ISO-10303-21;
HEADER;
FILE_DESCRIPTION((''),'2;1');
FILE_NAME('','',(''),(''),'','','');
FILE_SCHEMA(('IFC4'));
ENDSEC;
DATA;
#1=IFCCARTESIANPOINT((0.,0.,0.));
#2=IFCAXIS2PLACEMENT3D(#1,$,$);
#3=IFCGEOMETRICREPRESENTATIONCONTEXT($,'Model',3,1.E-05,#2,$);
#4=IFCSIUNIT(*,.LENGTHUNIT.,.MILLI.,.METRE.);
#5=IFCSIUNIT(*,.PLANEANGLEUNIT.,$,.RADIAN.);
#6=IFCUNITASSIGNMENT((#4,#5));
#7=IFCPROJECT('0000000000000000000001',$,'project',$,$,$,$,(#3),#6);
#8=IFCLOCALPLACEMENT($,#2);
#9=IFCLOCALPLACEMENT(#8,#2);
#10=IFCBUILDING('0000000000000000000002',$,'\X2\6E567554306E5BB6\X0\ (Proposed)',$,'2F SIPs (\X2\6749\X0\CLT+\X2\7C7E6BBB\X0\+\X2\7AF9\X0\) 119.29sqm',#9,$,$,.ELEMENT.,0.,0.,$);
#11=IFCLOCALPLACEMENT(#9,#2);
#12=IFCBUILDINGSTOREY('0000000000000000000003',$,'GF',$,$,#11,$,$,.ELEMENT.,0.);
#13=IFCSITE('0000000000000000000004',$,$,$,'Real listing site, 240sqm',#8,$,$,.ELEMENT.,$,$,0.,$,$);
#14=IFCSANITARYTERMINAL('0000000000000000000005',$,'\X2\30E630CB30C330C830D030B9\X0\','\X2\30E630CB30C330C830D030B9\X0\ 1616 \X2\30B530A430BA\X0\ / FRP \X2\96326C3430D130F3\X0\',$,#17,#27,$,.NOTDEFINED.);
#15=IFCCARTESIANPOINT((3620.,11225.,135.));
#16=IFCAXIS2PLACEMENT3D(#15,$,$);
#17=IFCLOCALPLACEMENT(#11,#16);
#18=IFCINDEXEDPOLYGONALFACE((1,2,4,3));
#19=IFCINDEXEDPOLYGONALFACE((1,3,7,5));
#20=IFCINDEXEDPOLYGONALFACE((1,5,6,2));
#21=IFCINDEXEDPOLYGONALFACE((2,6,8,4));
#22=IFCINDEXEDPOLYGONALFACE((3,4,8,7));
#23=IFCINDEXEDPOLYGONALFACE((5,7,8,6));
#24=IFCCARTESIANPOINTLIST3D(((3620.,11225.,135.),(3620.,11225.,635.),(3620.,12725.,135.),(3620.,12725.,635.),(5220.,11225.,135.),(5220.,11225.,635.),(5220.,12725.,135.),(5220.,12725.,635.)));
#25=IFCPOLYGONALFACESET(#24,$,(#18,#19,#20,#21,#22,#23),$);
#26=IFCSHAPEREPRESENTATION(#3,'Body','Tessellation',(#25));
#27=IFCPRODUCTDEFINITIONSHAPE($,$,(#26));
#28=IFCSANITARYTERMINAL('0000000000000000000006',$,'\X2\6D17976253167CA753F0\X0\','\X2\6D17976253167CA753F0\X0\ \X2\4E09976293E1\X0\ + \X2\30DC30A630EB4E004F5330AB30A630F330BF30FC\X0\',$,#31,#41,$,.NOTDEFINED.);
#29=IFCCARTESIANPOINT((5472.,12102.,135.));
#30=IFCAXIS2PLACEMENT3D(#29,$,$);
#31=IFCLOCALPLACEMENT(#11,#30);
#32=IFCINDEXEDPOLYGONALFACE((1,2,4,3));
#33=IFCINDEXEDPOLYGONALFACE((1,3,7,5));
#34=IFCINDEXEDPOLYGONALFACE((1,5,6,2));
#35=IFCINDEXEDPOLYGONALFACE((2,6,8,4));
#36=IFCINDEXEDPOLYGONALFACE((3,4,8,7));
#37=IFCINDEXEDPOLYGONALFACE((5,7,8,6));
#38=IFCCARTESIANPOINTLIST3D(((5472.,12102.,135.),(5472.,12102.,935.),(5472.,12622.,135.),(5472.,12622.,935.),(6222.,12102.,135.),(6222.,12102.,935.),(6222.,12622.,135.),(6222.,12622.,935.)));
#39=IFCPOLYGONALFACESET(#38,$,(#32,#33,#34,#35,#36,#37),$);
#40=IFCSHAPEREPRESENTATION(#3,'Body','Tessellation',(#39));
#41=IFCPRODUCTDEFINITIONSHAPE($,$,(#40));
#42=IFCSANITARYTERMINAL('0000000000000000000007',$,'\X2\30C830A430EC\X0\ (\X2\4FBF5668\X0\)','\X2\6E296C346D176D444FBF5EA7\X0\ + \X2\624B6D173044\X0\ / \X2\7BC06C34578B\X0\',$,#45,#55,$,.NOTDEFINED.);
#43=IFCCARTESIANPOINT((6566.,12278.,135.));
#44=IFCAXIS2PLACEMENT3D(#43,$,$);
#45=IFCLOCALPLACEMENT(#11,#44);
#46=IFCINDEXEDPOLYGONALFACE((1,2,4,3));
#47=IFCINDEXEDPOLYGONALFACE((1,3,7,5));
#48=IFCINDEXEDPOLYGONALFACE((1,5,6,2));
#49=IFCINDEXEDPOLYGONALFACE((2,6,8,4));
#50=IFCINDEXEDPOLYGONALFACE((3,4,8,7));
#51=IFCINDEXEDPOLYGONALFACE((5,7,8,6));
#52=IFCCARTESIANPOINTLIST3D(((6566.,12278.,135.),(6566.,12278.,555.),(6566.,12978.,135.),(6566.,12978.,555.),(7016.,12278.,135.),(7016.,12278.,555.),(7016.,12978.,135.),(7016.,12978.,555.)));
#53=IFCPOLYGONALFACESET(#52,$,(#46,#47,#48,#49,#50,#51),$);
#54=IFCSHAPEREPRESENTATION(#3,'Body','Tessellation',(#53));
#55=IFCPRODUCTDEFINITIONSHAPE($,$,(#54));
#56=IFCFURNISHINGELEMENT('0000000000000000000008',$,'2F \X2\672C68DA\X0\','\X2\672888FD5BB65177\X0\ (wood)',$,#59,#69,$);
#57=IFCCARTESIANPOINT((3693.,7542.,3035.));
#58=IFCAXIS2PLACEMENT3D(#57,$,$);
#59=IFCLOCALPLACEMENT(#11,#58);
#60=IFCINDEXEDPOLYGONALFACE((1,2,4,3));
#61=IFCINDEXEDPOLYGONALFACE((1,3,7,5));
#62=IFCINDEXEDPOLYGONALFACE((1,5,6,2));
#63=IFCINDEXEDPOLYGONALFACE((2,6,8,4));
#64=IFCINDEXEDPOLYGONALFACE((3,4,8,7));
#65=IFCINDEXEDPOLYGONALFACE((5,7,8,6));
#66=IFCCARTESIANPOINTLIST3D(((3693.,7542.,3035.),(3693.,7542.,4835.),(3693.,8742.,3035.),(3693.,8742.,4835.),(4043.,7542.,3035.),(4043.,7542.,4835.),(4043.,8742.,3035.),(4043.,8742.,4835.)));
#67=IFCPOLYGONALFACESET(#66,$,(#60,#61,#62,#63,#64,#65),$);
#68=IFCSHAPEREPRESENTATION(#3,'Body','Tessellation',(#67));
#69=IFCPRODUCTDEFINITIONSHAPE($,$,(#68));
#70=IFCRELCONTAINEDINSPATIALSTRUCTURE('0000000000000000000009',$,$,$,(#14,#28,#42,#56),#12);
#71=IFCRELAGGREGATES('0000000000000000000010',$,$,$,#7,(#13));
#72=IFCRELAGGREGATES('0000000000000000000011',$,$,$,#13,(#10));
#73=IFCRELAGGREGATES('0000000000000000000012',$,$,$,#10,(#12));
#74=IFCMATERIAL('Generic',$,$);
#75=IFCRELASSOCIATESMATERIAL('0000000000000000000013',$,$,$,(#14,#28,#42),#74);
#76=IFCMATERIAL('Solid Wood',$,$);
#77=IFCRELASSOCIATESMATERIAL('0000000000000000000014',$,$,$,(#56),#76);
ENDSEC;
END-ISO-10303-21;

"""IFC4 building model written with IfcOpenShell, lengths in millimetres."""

from ifc_helpers import new_model, si_unit, frame, frame_2d, origin, place, context, project, spatial, rectangle, extrude, material, element, save


model = new_model("IFC4")

# Units and contexts
model_context = context("Model", 3, precision=1e-05, world=origin())
ifc_project = project(units=[si_unit("LENGTHUNIT", "METRE", prefix="MILLI"), si_unit("PLANEANGLEUNIT", "RADIAN")], contexts=[model_context])

# Site, building, storey
site_placement = place(None, origin())
site = spatial("IfcSite", under=ifc_project, at=site_placement, ObjectType="Real listing site, 240sqm", CompositionType="ELEMENT", RefElevation=0.0)
building_placement = place(site_placement, origin())
building = spatial("IfcBuilding", under=site, at=building_placement, Name="湖畔の家 (Proposed)", ObjectType="2F SIPs (杉CLT+籾殻+竹) 119.29sqm", CompositionType="ELEMENT", ElevationOfRefHeight=0.0, ElevationOfTerrain=0.0)
storey_placement = place(building_placement, origin())
storey = spatial("IfcBuildingStorey", under=building, at=storey_placement, Name="GF", CompositionType="ELEMENT", Elevation=0.0)

# Shared definitions
ifc_material_1 = material(Name="Solid Wood")

# Shared definitions
ifc_material_2 = material(Name="Generic")

# Sanitary terminals
sanitary_terminal_1_placement = place(storey_placement, frame((3620.0, 11225.0, 135.0)))
element("IfcSanitaryTerminal", 1, at=sanitary_terminal_1_placement, inside=storey, material=ifc_material_2, Name="ユニットバス", Description="ユニットバス 1616 サイズ / FRP 防水パン", PredefinedType="NOTDEFINED", context=model_context, shape_type="SweptSolid", body=[
    extrude(rectangle(XDim=1600.0, YDim=1500.0, at=frame_2d((800.0, 750.0))), frame((3620.0, 11225.0, 135.0)), (0.0, 0.0, 1.0), 500.0),
])
sanitary_terminal_2_placement = place(storey_placement, frame((5472.0, 12102.0, 135.0)))
element("IfcSanitaryTerminal", 2, at=sanitary_terminal_2_placement, inside=storey, material=ifc_material_2, Name="洗面化粧台", Description="洗面化粧台 三面鏡 + ボウル一体カウンター", PredefinedType="NOTDEFINED", context=model_context, shape_type="SweptSolid", body=[
    extrude(rectangle(XDim=750.0, YDim=520.0, at=frame_2d((375.0, 260.0))), frame((5472.0, 12102.0, 135.0)), (0.0, 0.0, 1.0), 800.0),
])
sanitary_terminal_3_placement = place(storey_placement, frame((6566.0, 12278.0, 135.0)))
element("IfcSanitaryTerminal", 3, at=sanitary_terminal_3_placement, inside=storey, material=ifc_material_2, Name="トイレ (便器)", Description="温水洗浄便座 + 手洗い / 節水型", PredefinedType="NOTDEFINED", context=model_context, shape_type="SweptSolid", body=[
    extrude(rectangle(XDim=450.0, YDim=700.0, at=frame_2d((225.0, 350.0))), frame((6566.0, 12278.0, 135.0)), (0.0, 0.0, 1.0), 420.0),
])

# Furnishing element
furnishing_placement = place(storey_placement, frame((3693.0, 7542.0, 3035.0)))
element("IfcFurnishingElement", 4, at=furnishing_placement, inside=storey, material=ifc_material_1, Name="2F 本棚", Description="木製家具 (wood)", context=model_context, shape_type="SweptSolid", body=[
    extrude(rectangle(XDim=350.0, YDim=1200.0, at=frame_2d((175.0, 600.0))), frame((3693.0, 7542.0, 3035.0)), (0.0, 0.0, 1.0), 1800.0),
])

save(model, "model.ifc")
